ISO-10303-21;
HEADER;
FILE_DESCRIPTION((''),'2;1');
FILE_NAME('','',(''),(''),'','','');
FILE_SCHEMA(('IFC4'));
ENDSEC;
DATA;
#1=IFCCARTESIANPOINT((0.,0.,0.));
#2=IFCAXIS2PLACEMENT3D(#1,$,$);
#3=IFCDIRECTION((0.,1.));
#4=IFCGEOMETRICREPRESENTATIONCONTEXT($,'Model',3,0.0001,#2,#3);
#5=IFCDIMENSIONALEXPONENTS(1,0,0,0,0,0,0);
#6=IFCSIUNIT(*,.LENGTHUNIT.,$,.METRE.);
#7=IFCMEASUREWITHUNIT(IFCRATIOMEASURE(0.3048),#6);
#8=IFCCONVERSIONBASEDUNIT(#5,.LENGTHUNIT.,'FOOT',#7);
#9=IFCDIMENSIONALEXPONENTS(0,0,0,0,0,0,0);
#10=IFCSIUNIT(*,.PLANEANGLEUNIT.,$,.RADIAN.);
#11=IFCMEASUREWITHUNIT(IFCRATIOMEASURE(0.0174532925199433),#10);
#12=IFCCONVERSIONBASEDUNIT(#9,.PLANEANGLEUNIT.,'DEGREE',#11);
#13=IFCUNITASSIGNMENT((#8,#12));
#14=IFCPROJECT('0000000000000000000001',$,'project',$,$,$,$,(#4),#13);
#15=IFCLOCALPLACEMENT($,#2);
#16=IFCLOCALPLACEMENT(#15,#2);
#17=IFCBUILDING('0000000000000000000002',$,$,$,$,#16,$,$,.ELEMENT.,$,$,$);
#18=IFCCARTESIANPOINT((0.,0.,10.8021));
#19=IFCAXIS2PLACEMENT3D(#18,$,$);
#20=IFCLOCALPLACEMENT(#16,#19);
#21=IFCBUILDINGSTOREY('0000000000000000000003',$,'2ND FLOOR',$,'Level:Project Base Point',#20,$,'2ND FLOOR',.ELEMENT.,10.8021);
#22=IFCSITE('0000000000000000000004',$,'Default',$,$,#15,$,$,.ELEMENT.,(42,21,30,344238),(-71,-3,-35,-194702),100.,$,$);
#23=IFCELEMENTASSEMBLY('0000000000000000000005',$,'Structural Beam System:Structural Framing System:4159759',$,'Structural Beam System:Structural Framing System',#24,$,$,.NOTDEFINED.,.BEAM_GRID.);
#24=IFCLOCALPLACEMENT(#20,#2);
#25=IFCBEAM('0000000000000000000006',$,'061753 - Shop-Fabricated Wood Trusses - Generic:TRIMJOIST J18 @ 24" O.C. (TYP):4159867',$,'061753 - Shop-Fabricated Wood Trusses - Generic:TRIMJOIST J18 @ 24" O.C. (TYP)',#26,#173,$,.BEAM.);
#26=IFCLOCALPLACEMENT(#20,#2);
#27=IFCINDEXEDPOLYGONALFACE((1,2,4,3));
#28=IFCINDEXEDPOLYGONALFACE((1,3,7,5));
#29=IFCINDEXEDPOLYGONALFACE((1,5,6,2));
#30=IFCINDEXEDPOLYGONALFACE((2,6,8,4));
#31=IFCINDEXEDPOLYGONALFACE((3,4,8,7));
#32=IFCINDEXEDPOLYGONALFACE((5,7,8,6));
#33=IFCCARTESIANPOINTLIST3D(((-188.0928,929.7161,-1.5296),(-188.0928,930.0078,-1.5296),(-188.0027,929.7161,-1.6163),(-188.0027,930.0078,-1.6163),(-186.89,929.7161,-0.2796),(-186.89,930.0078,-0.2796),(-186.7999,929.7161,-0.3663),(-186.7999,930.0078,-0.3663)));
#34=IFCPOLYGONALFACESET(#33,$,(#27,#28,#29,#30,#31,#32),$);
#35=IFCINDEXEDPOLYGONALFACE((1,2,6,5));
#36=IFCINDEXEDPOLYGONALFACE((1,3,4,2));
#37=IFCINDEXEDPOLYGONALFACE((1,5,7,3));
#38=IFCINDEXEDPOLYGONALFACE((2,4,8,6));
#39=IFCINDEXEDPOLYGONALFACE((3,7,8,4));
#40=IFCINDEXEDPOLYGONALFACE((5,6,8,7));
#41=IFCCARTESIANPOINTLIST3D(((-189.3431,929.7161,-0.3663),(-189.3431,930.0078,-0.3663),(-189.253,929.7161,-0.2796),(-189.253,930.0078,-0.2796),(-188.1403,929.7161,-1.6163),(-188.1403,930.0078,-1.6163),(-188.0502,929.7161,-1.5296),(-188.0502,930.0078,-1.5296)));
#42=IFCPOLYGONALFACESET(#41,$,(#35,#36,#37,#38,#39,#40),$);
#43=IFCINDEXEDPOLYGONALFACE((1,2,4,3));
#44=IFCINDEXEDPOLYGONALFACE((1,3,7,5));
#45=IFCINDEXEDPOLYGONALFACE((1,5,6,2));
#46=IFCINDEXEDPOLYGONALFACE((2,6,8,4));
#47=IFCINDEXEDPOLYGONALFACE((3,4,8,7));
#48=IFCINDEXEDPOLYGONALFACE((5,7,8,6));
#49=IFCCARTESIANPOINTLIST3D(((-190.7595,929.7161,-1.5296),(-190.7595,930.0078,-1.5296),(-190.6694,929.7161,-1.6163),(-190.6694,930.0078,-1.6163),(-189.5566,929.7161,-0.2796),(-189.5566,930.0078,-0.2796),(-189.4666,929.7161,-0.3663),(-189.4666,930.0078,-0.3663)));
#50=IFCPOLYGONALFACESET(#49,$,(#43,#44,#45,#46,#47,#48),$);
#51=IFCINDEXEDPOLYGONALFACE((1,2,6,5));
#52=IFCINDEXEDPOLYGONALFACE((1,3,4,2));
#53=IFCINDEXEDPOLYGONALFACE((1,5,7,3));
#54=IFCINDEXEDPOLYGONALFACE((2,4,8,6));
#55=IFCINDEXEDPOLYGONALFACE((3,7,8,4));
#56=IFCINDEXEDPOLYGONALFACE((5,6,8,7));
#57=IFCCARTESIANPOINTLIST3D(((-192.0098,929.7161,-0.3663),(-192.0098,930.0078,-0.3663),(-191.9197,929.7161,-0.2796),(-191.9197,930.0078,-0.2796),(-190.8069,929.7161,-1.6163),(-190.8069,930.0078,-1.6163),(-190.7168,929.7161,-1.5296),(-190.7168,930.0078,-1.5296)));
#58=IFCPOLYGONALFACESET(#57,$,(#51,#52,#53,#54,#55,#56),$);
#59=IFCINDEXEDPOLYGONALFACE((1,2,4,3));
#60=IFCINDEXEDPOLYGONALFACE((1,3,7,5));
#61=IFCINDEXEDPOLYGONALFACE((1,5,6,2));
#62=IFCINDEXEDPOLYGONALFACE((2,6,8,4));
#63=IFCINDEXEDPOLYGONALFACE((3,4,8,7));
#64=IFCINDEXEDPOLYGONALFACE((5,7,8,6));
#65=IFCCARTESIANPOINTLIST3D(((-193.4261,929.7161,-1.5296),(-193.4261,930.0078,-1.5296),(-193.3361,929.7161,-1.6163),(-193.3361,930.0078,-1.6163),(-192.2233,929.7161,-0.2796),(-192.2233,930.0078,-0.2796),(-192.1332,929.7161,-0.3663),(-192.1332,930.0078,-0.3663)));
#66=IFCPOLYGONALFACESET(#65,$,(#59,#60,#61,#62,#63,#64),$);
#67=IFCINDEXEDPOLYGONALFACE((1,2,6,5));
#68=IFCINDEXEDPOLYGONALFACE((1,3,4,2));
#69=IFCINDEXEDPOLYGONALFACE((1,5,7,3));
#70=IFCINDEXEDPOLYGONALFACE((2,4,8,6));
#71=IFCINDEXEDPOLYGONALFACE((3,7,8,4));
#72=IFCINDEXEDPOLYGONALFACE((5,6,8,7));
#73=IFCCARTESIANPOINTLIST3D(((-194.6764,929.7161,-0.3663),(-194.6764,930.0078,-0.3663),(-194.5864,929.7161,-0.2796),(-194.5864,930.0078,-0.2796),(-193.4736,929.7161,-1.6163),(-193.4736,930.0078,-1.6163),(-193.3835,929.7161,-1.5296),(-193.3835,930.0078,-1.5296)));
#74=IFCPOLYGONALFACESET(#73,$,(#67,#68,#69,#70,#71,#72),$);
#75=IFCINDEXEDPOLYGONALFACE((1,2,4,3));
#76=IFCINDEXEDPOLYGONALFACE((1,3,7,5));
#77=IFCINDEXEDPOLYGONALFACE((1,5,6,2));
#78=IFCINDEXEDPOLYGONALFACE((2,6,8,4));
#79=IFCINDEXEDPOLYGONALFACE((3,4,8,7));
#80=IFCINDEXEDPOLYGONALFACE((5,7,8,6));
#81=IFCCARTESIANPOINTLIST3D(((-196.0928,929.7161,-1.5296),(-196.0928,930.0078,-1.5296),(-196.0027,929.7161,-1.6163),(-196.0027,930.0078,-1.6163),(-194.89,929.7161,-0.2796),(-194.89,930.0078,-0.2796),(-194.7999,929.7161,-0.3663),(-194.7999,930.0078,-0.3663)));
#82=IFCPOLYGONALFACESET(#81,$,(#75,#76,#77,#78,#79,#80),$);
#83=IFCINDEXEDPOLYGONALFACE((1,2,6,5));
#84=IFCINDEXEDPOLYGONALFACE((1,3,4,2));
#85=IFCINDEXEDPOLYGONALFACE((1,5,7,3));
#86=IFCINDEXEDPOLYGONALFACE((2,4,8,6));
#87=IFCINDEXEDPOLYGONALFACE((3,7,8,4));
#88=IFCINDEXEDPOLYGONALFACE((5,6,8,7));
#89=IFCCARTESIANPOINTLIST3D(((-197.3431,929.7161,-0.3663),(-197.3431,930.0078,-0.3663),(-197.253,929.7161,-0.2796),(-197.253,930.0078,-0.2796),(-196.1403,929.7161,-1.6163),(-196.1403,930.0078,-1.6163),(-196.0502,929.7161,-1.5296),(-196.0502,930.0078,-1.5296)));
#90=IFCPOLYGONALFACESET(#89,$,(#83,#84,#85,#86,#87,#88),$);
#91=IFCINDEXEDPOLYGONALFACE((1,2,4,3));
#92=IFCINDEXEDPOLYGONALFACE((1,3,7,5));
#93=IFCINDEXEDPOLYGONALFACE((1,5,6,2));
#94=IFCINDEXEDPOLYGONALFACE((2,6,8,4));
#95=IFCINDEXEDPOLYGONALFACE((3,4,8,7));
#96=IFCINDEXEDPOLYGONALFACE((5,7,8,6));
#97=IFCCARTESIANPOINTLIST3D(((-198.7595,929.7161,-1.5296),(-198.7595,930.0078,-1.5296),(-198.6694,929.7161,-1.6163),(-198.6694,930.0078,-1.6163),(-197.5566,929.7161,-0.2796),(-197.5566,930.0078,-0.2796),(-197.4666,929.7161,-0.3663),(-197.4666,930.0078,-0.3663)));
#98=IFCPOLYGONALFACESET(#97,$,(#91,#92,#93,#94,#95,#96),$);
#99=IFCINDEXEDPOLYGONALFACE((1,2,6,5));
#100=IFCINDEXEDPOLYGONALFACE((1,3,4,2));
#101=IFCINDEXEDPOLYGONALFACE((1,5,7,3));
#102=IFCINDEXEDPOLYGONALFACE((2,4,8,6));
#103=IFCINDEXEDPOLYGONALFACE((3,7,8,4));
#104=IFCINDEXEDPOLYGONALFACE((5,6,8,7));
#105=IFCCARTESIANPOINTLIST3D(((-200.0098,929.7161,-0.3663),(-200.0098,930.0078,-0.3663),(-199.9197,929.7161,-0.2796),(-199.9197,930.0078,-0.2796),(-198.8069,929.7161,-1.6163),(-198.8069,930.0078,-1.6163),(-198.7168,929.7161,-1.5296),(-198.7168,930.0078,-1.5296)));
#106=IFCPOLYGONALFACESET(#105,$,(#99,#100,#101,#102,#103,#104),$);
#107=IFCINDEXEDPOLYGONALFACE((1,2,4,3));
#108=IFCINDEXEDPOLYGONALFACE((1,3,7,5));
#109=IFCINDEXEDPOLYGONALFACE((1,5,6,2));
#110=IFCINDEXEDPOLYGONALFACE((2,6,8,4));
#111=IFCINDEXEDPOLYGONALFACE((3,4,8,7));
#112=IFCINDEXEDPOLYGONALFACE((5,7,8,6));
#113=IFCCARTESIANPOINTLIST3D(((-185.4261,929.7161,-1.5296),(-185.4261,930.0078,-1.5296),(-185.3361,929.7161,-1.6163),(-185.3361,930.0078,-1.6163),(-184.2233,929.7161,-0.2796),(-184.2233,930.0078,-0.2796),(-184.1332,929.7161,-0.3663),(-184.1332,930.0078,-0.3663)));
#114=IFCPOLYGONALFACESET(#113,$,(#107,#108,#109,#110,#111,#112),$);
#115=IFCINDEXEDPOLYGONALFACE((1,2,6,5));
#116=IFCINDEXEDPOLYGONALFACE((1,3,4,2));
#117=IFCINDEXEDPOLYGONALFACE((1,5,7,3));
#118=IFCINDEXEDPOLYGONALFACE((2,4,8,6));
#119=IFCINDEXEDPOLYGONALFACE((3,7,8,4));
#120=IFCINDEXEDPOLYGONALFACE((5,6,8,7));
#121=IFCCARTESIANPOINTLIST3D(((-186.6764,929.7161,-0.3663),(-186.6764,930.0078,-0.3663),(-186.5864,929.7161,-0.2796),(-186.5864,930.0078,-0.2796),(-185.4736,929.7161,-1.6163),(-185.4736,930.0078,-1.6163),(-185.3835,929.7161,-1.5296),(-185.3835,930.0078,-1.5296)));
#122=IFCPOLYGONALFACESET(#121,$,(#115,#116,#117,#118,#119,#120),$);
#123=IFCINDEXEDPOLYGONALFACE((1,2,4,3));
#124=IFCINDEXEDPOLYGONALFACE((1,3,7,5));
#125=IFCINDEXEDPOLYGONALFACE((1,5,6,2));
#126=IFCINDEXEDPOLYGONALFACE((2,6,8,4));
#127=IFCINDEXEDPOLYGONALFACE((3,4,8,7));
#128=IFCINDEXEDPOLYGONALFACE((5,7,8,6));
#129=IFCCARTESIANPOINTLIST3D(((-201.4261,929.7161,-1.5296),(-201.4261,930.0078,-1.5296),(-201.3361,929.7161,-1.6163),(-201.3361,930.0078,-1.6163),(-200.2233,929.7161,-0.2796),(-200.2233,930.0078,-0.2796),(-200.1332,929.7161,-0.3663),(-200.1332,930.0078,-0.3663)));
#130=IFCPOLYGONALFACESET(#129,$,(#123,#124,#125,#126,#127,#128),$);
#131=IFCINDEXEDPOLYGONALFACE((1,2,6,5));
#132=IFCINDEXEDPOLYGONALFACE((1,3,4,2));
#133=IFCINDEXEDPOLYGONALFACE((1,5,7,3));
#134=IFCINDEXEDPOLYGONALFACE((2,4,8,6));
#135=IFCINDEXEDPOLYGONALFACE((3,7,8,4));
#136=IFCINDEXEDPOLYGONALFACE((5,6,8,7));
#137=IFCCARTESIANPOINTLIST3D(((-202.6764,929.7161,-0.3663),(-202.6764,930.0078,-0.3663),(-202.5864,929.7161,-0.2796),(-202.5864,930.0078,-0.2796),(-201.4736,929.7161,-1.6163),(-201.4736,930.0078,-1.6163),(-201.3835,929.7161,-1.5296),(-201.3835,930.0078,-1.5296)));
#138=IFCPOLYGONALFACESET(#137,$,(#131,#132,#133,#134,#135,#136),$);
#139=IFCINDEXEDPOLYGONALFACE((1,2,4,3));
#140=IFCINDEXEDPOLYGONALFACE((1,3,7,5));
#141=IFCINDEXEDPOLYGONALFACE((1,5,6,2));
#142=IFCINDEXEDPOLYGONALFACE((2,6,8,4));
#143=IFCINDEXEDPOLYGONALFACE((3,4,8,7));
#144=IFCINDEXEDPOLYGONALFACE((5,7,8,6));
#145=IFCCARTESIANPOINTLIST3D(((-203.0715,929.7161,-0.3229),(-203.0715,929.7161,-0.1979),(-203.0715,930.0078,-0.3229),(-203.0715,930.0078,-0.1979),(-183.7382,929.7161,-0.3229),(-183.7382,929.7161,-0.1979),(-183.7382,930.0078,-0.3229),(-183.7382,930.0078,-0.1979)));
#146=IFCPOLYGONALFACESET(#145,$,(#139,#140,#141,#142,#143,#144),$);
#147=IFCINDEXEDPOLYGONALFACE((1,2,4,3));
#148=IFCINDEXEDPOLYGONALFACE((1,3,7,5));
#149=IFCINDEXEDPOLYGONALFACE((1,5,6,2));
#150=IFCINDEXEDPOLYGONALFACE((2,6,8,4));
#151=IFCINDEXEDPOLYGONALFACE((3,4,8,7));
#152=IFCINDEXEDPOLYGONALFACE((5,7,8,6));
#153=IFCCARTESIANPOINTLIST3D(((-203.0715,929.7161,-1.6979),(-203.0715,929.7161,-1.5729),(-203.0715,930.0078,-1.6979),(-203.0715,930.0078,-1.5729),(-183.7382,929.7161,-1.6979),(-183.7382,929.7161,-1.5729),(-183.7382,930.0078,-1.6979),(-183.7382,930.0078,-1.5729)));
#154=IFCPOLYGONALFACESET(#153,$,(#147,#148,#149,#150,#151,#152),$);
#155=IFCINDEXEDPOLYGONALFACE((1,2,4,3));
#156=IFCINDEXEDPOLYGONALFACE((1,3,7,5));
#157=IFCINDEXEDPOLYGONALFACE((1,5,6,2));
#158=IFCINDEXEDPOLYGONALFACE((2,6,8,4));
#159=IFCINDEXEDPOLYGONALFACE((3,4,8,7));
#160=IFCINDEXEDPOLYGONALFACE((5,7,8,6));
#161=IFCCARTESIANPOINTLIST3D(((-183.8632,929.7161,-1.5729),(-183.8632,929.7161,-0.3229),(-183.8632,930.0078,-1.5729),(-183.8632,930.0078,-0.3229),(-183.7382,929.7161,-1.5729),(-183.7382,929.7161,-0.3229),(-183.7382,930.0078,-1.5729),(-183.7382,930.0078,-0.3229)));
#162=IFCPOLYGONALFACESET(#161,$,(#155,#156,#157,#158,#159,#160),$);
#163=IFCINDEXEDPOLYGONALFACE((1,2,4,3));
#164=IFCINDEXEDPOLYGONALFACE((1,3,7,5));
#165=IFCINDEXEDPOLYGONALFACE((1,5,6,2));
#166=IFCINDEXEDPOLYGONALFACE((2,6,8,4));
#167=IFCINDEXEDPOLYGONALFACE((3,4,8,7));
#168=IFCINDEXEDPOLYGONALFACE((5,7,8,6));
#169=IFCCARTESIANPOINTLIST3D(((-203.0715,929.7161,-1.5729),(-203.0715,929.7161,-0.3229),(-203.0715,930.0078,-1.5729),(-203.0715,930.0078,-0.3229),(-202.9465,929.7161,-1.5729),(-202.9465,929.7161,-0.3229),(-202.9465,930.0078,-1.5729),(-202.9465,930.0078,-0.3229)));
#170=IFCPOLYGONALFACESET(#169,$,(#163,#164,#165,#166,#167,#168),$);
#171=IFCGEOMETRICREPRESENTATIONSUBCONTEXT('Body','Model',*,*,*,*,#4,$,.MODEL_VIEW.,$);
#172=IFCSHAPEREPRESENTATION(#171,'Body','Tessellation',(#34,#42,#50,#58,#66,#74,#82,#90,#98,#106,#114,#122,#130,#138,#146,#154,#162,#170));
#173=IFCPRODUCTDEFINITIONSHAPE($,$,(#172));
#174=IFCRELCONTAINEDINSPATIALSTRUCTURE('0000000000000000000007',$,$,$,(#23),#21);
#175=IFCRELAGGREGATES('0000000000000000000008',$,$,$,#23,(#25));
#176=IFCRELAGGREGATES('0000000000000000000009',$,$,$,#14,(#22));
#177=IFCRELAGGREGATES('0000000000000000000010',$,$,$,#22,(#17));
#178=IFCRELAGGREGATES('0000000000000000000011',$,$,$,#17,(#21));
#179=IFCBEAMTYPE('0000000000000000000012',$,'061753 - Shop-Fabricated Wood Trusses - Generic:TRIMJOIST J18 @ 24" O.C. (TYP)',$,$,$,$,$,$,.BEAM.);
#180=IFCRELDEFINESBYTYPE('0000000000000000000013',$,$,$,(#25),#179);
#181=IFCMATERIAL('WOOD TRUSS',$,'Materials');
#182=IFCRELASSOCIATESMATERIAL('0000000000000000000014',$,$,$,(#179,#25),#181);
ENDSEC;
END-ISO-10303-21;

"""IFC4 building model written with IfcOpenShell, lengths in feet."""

from ifc_helpers import new_model, entity, si_unit, converted_unit, direction, frame, frame_2d, origin, origin_2d_with_axis, place, context, subcontext, project, spatial, rectangle, extrude, source, transform, mapped, material, material_profile, profile_set, profile_usage, type_object, type_shapes, element, aggregate, save


model = new_model("IFC4")

# Units and contexts
model_context = context("Model", 3, precision=0.0001, world=origin(), true_north=direction((0.0, 1.0)))
body_context = subcontext(model_context, "Body", "Model", "MODEL_VIEW")
ifc_project = project(units=[converted_unit("LENGTHUNIT", "FOOT", entity("IfcRatioMeasure", 0.3048), si_unit("LENGTHUNIT", "METRE"), dimensions=[1, 0, 0, 0, 0, 0, 0]), converted_unit("PLANEANGLEUNIT", "DEGREE", entity("IfcRatioMeasure", 0.0174532925199433), si_unit("PLANEANGLEUNIT", "RADIAN"), dimensions=[0, 0, 0, 0, 0, 0, 0])], contexts=[model_context])

# Site, building, storey
site_placement = place(None, origin())
site = spatial("IfcSite", under=ifc_project, at=site_placement, Name="Default", CompositionType="ELEMENT", RefLatitude=(42, 21, 30, 344238), RefLongitude=(-71, -3, -35, -194702), RefElevation=100.0)
building_placement = place(site_placement, origin())
building = spatial("IfcBuilding", under=site, at=building_placement, CompositionType="ELEMENT")
storey_placement = place(building_placement, frame((0.0, 0.0, 10.8021)))
storey = spatial("IfcBuildingStorey", under=building, at=storey_placement, Name="2ND FLOOR", ObjectType="Level:Project Base Point", LongName="2ND FLOOR", CompositionType="ELEMENT", Elevation=10.8021)

# Element assembly, beam
ifc_material_1 = material(Name="WOOD TRUSS", Category="Materials")
ifc_material_profile_1 = material_profile(ifc_material_1, rectangle(XDim=1.7347, YDim=0.125, at=frame_2d((0.0, 0.0), x_axis=(1.0, 0.0))), Name="TRIMJOIST J18 @ 24\" O.C. (TYP)")
ifc_material_profile_2 = material_profile(ifc_material_1, rectangle(XDim=1.7347, YDim=0.125, at=frame_2d((0.0, 0.0), x_axis=(1.0, 0.0))), Name="TRIMJOIST J18 @ 24\" O.C. (TYP)")
ifc_material_profile_3 = material_profile(ifc_material_1, rectangle(XDim=1.7347, YDim=0.125, at=frame_2d((0.0, 0.0), x_axis=(1.0, 0.0))), Name="TRIMJOIST J18 @ 24\" O.C. (TYP)")
ifc_material_profile_4 = material_profile(ifc_material_1, rectangle(XDim=1.7347, YDim=0.125, at=frame_2d((0.0, 0.0), x_axis=(1.0, 0.0))), Name="TRIMJOIST J18 @ 24\" O.C. (TYP)")
ifc_material_profile_5 = material_profile(ifc_material_1, rectangle(XDim=1.7347, YDim=0.125, at=frame_2d((0.0, 0.0), x_axis=(1.0, 0.0))), Name="TRIMJOIST J18 @ 24\" O.C. (TYP)")
ifc_material_profile_6 = material_profile(ifc_material_1, rectangle(XDim=1.7347, YDim=0.125, at=frame_2d((0.0, 0.0), x_axis=(1.0, 0.0))), Name="TRIMJOIST J18 @ 24\" O.C. (TYP)")
ifc_material_profile_7 = material_profile(ifc_material_1, rectangle(XDim=1.7347, YDim=0.125, at=frame_2d((0.0, 0.0), x_axis=(1.0, 0.0))), Name="TRIMJOIST J18 @ 24\" O.C. (TYP)")
ifc_material_profile_8 = material_profile(ifc_material_1, rectangle(XDim=1.7347, YDim=0.125, at=frame_2d((0.0, 0.0), x_axis=(1.0, 0.0))), Name="TRIMJOIST J18 @ 24\" O.C. (TYP)")
ifc_material_profile_9 = material_profile(ifc_material_1, rectangle(XDim=1.7347, YDim=0.125, at=frame_2d((0.0, 0.0), x_axis=(1.0, 0.0))), Name="TRIMJOIST J18 @ 24\" O.C. (TYP)")
ifc_material_profile_10 = material_profile(ifc_material_1, rectangle(XDim=1.7347, YDim=0.125, at=origin_2d_with_axis()), Name="TRIMJOIST J18 @ 24\" O.C. (TYP)")
ifc_material_profile_11 = material_profile(ifc_material_1, rectangle(XDim=0.125, YDim=0.2917, at=origin_2d_with_axis()), Name="TRIMJOIST J18 @ 24\" O.C. (TYP)")
ifc_material_profile_12 = material_profile(ifc_material_1, rectangle(XDim=0.125, YDim=0.2917, at=origin_2d_with_axis()), Name="TRIMJOIST J18 @ 24\" O.C. (TYP)")
ifc_material_profile_13 = material_profile(ifc_material_1, rectangle(XDim=1.25, YDim=0.2917, at=origin_2d_with_axis()), Name="TRIMJOIST J18 @ 24\" O.C. (TYP)")
ifc_material_profile_14 = material_profile(ifc_material_1, rectangle(XDim=1.25, YDim=0.2917, at=origin_2d_with_axis()), Name="TRIMJOIST J18 @ 24\" O.C. (TYP)")
ifc_profile_set_1 = profile_set([ifc_material_profile_1, ifc_material_profile_2, ifc_material_profile_3, ifc_material_profile_4, ifc_material_profile_5, ifc_material_profile_6, ifc_material_profile_7, ifc_material_profile_8, ifc_material_profile_9, ifc_material_profile_10, ifc_material_profile_11, ifc_material_profile_12, ifc_material_profile_13, ifc_material_profile_14], Name="TRIMJOIST J18 @ 24\" O.C. (TYP)")
beam_type_1 = type_object("IfcBeamType", Name="061753 - Shop-Fabricated Wood Trusses - Generic:TRIMJOIST J18 @ 24\" O.C. (TYP)", PredefinedType="BEAM", material=ifc_profile_set_1)
shared_shape_1 = source(origin(), body_context, "Body", "SweptSolid", [
    extrude(rectangle(XDim=1.7347, YDim=0.125, at=frame_2d((0.0, 0.0), x_axis=(1.0, 0.0))), frame((5.9585, -0.1458, 0.0), z_axis=(0.0, 1.0, 0.0), x_axis=(0.693383, 0.0, 0.720569)), (0.0, 0.0, 1.0), 0.2917),
    extrude(rectangle(XDim=1.7347, YDim=0.125, at=origin_2d_with_axis()), frame((4.7082, -0.1458, 0.0), z_axis=(0.0, 1.0, 0.0), x_axis=(0.693383, 0.0, -0.720569)), (0.0, 0.0, 1.0), 0.2917),
    extrude(rectangle(XDim=1.7347, YDim=0.125, at=frame_2d((0.0, 0.0), x_axis=(1.0, 0.0))), frame((3.2918, -0.1458, 0.0), z_axis=(0.0, 1.0, 0.0), x_axis=(0.693383, 0.0, 0.720569)), (0.0, 0.0, 1.0), 0.2917),
    extrude(rectangle(XDim=1.7347, YDim=0.125, at=frame_2d((0.0, 0.0), x_axis=(1.0, 0.0))), frame((2.0415, -0.1458, 0.0), z_axis=(0.0, 1.0, 0.0), x_axis=(0.693383, 0.0, -0.720569)), (0.0, 0.0, 1.0), 0.2917),
    extrude(rectangle(XDim=1.7347, YDim=0.125, at=frame_2d((0.0, 0.0), x_axis=(1.0, 0.0))), frame((0.6251, -0.1458, 0.0), z_axis=(0.0, 1.0, 0.0), x_axis=(0.693383, 0.0, 0.720569)), (0.0, 0.0, 1.0), 0.2917),
    extrude(rectangle(XDim=1.7347, YDim=0.125, at=frame_2d((0.0, 0.0), x_axis=(1.0, 0.0))), frame((-0.6251, -0.1458, 0.0), z_axis=(0.0, 1.0, 0.0), x_axis=(0.693383, 0.0, -0.720569)), (0.0, 0.0, 1.0), 0.2917),
    extrude(rectangle(XDim=1.7347, YDim=0.125, at=frame_2d((0.0, 0.0), x_axis=(1.0, 0.0))), frame((-2.0415, -0.1458, 0.0), z_axis=(0.0, 1.0, 0.0), x_axis=(0.693383, 0.0, 0.720569)), (0.0, 0.0, 1.0), 0.2917),
    extrude(rectangle(XDim=1.7347, YDim=0.125, at=origin_2d_with_axis()), frame((-3.2918, -0.1458, 0.0), z_axis=(0.0, 1.0, 0.0), x_axis=(0.693383, 0.0, -0.720569)), (0.0, 0.0, 1.0), 0.2917),
    extrude(rectangle(XDim=1.7347, YDim=0.125, at=frame_2d((0.0, 0.0), x_axis=(1.0, 0.0))), frame((-4.7082, -0.1458, 0.0), z_axis=(0.0, 1.0, 0.0), x_axis=(0.693383, 0.0, 0.720569)), (0.0, 0.0, 1.0), 0.2917),
    extrude(rectangle(XDim=1.7347, YDim=0.125, at=frame_2d((0.0, 0.0), x_axis=(1.0, 0.0))), frame((-5.9585, -0.1458, 0.0), z_axis=(0.0, 1.0, 0.0), x_axis=(0.693383, 0.0, -0.720569)), (0.0, 0.0, 1.0), 0.2917),
    extrude(rectangle(XDim=1.7347, YDim=0.125, at=frame_2d((0.0, 0.0), x_axis=(1.0, 0.0))), frame((8.6251, -0.1458, 0.0), z_axis=(0.0, 1.0, 0.0), x_axis=(0.693383, 0.0, 0.720569)), (0.0, 0.0, 1.0), 0.2917),
    extrude(rectangle(XDim=1.7347, YDim=0.125, at=origin_2d_with_axis()), frame((7.3749, -0.1458, 0.0), z_axis=(0.0, 1.0, 0.0), x_axis=(0.693383, 0.0, -0.720569)), (0.0, 0.0, 1.0), 0.2917),
    extrude(rectangle(XDim=1.7347, YDim=0.125, at=frame_2d((0.0, 0.0), x_axis=(1.0, 0.0))), frame((-7.3749, -0.1458, 0.0), z_axis=(0.0, 1.0, 0.0), x_axis=(0.693383, 0.0, 0.720569)), (0.0, 0.0, 1.0), 0.2917),
    extrude(rectangle(XDim=1.7347, YDim=0.125, at=origin_2d_with_axis()), frame((-8.6251, -0.1458, 0.0), z_axis=(0.0, 1.0, 0.0), x_axis=(0.693383, 0.0, -0.720569)), (0.0, 0.0, 1.0), 0.2917),
    extrude(rectangle(XDim=0.125, YDim=0.2917, at=origin_2d_with_axis()), frame((-9.6667, 0.0, 0.6875), z_axis=(1.0, 0.0, 0.0), x_axis=(0.0, 0.0, -1.0)), (0.0, 0.0, 1.0), 19.3333),
    extrude(rectangle(XDim=0.125, YDim=0.2917, at=origin_2d_with_axis()), frame((-9.6667, 0.0, -0.6875), z_axis=(1.0, 0.0, 0.0), x_axis=(0.0, 0.0, -1.0)), (0.0, 0.0, 1.0), 19.3333),
    extrude(rectangle(XDim=1.25, YDim=0.2917, at=origin_2d_with_axis()), frame((9.5417, 0.0, 0.0), z_axis=(1.0, 0.0, 0.0), x_axis=(0.0, 0.0, -1.0)), (0.0, 0.0, 1.0), 0.125),
    extrude(rectangle(XDim=1.25, YDim=0.2917, at=origin_2d_with_axis()), frame((-9.6667, 0.0, 0.0), z_axis=(1.0, 0.0, 0.0), x_axis=(0.0, 0.0, -1.0)), (0.0, 0.0, 1.0), 0.125),
])
type_shapes(beam_type_1, [shared_shape_1])
assembly_1_placement = place(storey_placement, origin())
assembly_1 = element("IfcElementAssembly", 1, at=assembly_1_placement, inside=storey, Name="Structural Beam System:Structural Framing System:4159759", ObjectType="Structural Beam System:Structural Framing System", AssemblyPlace="NOTDEFINED", PredefinedType="BEAM_GRID")
ifc_profile_usage_1 = profile_usage(ifc_profile_set_1, cardinal=8)
beam_1_placement = place(assembly_1_placement, frame((-193.4048, 929.8619, -0.9479)))
beam_1 = element("IfcBeam", 2, at=beam_1_placement, type_object=beam_type_1, material=ifc_profile_usage_1, Name="061753 - Shop-Fabricated Wood Trusses - Generic:TRIMJOIST J18 @ 24\" O.C. (TYP):4159867", ObjectType="061753 - Shop-Fabricated Wood Trusses - Generic:TRIMJOIST J18 @ 24\" O.C. (TYP)", PredefinedType="BEAM", context=body_context, shape_type="MappedRepresentation", body=[
    mapped(shared_shape_1, transform((0.0, 0.0, 0.0), scale=1.0)),
])
aggregate(assembly_1, [beam_1])

save(model, "model.ifc")
